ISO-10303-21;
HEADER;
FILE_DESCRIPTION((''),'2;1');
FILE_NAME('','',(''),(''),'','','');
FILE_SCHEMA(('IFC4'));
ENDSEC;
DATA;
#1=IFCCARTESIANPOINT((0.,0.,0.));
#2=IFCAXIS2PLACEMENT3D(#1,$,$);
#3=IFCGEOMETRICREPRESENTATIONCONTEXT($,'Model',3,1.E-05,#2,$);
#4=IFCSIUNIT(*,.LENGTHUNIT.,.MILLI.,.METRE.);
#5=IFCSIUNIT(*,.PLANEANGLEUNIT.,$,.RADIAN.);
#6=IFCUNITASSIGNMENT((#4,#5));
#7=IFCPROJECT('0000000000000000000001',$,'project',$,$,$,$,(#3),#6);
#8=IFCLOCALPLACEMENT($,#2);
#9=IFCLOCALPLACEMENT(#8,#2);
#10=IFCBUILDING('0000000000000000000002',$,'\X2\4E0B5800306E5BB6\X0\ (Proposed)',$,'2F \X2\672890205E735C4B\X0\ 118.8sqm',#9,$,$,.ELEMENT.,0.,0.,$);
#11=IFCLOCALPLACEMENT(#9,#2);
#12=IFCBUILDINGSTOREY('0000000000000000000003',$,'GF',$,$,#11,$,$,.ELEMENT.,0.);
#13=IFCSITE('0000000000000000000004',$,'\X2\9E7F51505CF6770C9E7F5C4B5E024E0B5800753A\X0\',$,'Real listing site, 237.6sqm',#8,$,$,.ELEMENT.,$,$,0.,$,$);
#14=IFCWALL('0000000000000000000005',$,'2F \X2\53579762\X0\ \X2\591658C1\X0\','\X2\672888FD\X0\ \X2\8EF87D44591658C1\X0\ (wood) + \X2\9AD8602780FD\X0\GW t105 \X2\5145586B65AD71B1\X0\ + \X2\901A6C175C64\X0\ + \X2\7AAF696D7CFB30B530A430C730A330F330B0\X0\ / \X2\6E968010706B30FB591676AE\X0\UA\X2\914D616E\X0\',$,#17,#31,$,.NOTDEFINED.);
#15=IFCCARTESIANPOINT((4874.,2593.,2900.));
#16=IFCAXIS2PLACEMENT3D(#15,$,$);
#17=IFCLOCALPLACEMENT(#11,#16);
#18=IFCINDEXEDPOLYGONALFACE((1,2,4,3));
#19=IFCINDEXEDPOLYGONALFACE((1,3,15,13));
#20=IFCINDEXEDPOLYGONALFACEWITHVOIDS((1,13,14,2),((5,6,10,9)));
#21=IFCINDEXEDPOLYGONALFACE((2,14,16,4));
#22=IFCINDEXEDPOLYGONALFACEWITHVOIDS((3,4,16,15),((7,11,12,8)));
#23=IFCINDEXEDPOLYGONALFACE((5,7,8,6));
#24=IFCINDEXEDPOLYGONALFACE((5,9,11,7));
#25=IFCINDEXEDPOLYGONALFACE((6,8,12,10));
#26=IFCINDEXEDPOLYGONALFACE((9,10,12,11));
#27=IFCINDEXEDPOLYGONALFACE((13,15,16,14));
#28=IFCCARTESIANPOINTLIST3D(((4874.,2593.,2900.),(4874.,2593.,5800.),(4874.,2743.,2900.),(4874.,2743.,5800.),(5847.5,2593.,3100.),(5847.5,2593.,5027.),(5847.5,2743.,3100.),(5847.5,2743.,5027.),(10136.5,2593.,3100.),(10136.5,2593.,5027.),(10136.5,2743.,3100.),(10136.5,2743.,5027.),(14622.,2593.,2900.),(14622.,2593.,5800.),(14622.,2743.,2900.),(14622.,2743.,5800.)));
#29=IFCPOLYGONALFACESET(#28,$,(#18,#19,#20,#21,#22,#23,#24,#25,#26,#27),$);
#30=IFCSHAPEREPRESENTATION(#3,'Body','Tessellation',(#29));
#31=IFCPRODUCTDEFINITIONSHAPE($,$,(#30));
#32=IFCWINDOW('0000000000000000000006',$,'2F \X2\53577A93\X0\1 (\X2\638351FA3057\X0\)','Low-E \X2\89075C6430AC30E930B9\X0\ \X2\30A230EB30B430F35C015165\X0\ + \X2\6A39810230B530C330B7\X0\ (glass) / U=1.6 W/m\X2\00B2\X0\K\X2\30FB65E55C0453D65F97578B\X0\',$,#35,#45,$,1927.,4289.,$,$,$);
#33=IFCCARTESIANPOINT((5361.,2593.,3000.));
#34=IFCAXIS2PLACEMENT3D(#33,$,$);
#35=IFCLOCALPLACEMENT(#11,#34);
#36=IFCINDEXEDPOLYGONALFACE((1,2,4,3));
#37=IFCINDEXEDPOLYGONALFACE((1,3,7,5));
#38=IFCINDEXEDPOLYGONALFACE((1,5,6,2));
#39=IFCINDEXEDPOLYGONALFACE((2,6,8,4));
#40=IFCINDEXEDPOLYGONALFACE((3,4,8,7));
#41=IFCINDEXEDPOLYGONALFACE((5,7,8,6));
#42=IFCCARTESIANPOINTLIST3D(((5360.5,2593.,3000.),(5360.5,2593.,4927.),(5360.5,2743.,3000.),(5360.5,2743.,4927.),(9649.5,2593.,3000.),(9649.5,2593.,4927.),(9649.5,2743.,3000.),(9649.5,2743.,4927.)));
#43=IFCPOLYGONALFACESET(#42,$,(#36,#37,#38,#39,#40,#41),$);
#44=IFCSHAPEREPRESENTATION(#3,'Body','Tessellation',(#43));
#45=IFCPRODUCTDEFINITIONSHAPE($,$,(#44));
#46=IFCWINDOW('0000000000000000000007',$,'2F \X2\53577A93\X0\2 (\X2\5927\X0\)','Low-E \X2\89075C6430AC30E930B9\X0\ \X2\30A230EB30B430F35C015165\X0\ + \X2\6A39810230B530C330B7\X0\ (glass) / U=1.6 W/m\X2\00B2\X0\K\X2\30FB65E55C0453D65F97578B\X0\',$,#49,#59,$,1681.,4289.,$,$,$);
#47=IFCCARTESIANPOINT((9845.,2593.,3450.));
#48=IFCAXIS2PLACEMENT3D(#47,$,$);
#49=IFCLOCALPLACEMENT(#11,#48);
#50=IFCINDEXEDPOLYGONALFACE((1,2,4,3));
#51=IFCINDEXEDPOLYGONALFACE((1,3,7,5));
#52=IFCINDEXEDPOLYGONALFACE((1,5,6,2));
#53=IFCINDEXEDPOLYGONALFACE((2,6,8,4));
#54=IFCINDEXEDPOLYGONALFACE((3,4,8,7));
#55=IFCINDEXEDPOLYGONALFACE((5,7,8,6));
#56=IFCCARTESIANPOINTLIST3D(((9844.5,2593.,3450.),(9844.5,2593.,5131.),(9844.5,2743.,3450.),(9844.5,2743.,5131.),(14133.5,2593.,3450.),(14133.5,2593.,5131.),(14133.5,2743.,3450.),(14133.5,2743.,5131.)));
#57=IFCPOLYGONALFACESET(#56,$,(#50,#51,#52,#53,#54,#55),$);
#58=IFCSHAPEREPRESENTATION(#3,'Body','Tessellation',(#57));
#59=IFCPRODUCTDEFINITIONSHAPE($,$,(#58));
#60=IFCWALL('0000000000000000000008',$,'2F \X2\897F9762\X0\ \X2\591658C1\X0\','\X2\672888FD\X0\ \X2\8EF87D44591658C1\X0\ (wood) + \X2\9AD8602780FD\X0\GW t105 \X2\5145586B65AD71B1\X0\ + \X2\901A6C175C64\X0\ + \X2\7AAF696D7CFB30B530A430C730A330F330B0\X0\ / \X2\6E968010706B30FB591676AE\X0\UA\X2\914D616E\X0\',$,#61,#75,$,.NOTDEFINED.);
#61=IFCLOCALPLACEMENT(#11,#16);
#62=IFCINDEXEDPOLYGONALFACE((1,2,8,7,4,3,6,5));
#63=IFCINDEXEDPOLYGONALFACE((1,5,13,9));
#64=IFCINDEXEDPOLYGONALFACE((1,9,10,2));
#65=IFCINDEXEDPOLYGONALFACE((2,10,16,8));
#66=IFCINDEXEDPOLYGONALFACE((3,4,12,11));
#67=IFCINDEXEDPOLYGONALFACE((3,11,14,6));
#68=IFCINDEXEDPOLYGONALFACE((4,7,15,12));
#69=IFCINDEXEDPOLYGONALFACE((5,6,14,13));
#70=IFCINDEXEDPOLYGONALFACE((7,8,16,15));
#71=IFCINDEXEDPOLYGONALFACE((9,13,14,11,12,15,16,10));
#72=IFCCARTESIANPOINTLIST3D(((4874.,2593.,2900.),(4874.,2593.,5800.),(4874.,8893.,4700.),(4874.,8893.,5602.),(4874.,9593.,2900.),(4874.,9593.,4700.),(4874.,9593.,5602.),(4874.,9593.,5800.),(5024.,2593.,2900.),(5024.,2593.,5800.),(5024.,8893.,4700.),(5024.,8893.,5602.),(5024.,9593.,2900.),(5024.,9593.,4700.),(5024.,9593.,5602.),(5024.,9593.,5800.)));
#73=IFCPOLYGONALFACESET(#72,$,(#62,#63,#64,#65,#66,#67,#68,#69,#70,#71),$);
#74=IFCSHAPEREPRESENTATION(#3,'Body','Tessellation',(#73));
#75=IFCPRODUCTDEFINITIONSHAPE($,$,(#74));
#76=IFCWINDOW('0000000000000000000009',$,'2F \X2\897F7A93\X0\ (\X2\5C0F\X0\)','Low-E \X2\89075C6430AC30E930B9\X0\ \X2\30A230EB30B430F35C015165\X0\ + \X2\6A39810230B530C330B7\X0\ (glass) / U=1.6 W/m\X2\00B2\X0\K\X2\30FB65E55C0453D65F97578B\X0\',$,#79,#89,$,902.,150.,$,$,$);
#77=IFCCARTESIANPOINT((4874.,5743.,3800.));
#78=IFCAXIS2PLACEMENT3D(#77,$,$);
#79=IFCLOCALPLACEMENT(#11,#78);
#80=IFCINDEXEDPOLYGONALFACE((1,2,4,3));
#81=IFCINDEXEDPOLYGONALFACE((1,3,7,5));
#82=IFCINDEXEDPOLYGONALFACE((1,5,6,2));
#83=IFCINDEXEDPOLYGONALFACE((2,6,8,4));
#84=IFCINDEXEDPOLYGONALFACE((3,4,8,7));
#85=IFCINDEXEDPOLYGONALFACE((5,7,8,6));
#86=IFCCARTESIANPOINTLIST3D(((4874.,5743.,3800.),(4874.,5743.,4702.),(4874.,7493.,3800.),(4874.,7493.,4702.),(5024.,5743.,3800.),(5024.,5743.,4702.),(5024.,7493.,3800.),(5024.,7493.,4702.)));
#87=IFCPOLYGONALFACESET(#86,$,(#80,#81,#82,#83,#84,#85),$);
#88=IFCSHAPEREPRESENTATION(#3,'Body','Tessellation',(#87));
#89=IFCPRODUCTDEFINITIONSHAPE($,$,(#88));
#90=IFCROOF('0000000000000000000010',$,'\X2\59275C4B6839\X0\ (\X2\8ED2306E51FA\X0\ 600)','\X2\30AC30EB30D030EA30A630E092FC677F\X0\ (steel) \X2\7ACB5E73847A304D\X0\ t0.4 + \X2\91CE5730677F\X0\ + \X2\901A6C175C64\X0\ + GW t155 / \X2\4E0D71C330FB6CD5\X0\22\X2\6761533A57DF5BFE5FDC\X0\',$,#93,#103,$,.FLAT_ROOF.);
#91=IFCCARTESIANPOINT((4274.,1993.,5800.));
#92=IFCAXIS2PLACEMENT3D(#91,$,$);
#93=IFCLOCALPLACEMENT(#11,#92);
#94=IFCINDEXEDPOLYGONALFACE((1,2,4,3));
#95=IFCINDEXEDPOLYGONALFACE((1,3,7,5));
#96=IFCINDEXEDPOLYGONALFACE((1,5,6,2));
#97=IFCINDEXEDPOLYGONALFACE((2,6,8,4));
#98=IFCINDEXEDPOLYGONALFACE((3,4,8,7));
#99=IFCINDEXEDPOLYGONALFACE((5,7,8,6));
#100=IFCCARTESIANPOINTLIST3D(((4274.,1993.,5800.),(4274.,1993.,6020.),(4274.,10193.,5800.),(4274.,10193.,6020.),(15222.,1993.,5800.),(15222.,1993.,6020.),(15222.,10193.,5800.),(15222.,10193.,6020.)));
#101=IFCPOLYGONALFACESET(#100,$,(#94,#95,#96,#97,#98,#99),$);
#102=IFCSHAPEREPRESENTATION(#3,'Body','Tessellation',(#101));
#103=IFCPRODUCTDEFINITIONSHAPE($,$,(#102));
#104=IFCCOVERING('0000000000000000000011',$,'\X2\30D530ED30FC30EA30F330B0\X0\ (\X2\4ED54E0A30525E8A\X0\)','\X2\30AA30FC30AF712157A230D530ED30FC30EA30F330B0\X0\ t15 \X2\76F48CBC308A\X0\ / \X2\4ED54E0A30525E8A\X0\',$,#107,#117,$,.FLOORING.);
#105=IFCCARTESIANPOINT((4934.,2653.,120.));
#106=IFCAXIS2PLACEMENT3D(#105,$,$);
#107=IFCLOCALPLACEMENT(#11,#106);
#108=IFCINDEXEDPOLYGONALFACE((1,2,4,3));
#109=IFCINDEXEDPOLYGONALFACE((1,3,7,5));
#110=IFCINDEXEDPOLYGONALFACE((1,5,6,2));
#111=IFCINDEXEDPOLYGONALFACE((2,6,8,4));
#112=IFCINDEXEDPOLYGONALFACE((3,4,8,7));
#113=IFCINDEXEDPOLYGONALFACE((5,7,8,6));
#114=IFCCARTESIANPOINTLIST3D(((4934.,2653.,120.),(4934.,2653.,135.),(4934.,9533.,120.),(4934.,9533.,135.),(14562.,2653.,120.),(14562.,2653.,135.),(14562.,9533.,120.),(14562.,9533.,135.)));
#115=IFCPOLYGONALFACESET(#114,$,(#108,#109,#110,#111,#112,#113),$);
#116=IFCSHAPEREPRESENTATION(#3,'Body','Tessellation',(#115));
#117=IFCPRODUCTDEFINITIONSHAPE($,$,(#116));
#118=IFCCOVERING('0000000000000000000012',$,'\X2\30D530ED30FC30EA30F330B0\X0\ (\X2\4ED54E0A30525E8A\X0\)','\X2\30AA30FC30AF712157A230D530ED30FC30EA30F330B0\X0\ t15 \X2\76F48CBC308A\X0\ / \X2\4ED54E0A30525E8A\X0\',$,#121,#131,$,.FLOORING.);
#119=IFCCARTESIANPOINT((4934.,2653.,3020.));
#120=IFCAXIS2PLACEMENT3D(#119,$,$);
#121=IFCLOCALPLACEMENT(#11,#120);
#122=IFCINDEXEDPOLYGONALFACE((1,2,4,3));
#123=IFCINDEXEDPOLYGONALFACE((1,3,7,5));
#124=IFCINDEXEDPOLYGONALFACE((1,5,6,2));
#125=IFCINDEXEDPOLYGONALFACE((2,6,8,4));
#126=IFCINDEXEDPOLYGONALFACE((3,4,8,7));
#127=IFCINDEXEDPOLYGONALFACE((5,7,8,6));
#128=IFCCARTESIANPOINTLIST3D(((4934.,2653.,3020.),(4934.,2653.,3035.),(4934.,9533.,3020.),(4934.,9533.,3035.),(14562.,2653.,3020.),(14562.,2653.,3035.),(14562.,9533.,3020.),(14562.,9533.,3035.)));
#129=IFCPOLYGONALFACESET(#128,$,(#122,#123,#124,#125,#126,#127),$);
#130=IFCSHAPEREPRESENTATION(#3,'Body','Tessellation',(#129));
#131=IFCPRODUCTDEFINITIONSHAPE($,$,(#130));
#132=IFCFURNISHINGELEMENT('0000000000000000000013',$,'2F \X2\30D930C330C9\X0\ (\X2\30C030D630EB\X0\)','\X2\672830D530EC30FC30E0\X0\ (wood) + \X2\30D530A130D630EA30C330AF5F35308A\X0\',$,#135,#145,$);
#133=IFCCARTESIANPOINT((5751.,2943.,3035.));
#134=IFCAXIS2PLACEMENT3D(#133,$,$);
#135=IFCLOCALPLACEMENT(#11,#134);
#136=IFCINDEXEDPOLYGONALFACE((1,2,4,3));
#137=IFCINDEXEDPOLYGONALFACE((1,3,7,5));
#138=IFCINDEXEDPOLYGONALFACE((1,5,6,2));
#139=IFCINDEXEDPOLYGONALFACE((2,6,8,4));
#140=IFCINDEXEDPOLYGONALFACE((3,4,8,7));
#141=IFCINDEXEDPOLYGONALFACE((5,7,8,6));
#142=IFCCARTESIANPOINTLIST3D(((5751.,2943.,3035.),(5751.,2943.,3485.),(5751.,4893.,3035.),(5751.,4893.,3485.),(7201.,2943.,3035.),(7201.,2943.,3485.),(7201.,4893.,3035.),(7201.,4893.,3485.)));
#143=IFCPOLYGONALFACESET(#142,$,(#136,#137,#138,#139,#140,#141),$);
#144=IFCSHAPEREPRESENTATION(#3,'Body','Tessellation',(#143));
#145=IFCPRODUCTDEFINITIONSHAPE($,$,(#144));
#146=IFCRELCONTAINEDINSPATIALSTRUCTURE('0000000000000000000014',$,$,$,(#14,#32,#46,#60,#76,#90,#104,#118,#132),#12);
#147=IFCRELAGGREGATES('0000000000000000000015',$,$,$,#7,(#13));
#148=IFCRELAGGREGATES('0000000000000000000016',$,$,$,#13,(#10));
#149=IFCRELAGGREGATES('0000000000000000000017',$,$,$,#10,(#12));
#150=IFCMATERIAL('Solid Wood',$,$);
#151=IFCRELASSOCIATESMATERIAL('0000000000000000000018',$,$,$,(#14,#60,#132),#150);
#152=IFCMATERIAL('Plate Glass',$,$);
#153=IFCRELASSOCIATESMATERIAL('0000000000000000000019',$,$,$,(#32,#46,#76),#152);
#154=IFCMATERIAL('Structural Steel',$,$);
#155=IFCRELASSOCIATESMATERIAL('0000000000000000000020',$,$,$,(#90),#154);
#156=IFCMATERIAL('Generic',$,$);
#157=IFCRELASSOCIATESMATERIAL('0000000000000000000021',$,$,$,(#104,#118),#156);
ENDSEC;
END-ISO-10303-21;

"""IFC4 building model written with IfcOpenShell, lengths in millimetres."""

from ifc_helpers import new_model, si_unit, frame, frame_2d, origin, place, context, project, spatial, rectangle, extrude, material, element, fill, save


model = new_model("IFC4")

# Units and contexts
model_context = context("Model", 3, precision=1e-05, world=origin())
ifc_project = project(units=[si_unit("LENGTHUNIT", "METRE", prefix="MILLI"), si_unit("PLANEANGLEUNIT", "RADIAN")], contexts=[model_context])

# Site, building, storey
site_placement = place(None, origin())
site = spatial("IfcSite", under=ifc_project, at=site_placement, Name="鹿児島県鹿屋市下堀町", ObjectType="Real listing site, 237.6sqm", CompositionType="ELEMENT", RefElevation=0.0)
building_placement = place(site_placement, origin())
building = spatial("IfcBuilding", under=site, at=building_placement, Name="下堀の家 (Proposed)", ObjectType="2F 木造平屋 118.8sqm", CompositionType="ELEMENT", ElevationOfRefHeight=0.0, ElevationOfTerrain=0.0)
storey_placement = place(building_placement, origin())
storey = spatial("IfcBuildingStorey", under=building, at=storey_placement, Name="GF", CompositionType="ELEMENT", Elevation=0.0)

# Shared definitions
ifc_material_1 = material(Name="Solid Wood")

# Shared definitions
ifc_material_2 = material(Name="Plate Glass")

# Wall, openings, windows
wall_1_placement = place(storey_placement, frame((4874.0, 2593.0, 2900.0)))
wall_1 = element("IfcWall", 1, at=wall_1_placement, inside=storey, material=ifc_material_1, Name="2F 南面 外壁", Description="木製 軸組外壁 (wood) + 高性能GW t105 充填断熱 + 通気層 + 窯業系サイディング / 準耐火・外皮UA配慮", PredefinedType="NOTDEFINED", context=model_context, shape_type="SweptSolid", body=[
    extrude(rectangle(XDim=9748.0, YDim=150.0, at=frame_2d((4874.0, 75.0))), frame((4874.0, 2593.0, 2900.0)), (0.0, 0.0, 1.0), 2900.0),
])
opening_1_placement = place(storey_placement, frame((5361.0, 2593.0, 3000.0)))
opening_1 = element("IfcOpeningElement", 2, at=opening_1_placement, cuts=wall_1, PredefinedType="NOTDEFINED", context=model_context, shape_type="SweptSolid", body=[
    extrude(rectangle(XDim=4289.0, YDim=150.0, at=frame_2d((2144.0, 75.0))), frame((5361.0, 2593.0, 3000.0)), (0.0, 0.0, 1.0), 1927.0),
])
opening_2_placement = place(storey_placement, frame((9845.0, 2593.0, 3450.0)))
opening_2 = element("IfcOpeningElement", 3, at=opening_2_placement, cuts=wall_1, PredefinedType="NOTDEFINED", context=model_context, shape_type="SweptSolid", body=[
    extrude(rectangle(XDim=4289.0, YDim=150.0, at=frame_2d((2144.0, 75.0))), frame((9845.0, 2593.0, 3450.0)), (0.0, 0.0, 1.0), 1681.0),
])
window_1_placement = place(storey_placement, frame((5361.0, 2593.0, 3000.0)))
window_1 = element("IfcWindow", 4, at=window_1_placement, inside=storey, material=ifc_material_2, Name="2F 南窓1 (掃出し)", Description="Low-E 複層ガラス アルゴン封入 + 樹脂サッシ (glass) / U=1.6 W/m²K・日射取得型", OverallHeight=1927.0, OverallWidth=4289.0, context=model_context, shape_type="SweptSolid", body=[
    extrude(rectangle(XDim=4289.0, YDim=150.0, at=frame_2d((2144.0, 75.0))), frame((5361.0, 2593.0, 3000.0)), (0.0, 0.0, 1.0), 1927.0),
])
fill(opening_1, window_1)
window_2_placement = place(storey_placement, frame((9845.0, 2593.0, 3450.0)))
window_2 = element("IfcWindow", 5, at=window_2_placement, inside=storey, material=ifc_material_2, Name="2F 南窓2 (大)", Description="Low-E 複層ガラス アルゴン封入 + 樹脂サッシ (glass) / U=1.6 W/m²K・日射取得型", OverallHeight=1681.0, OverallWidth=4289.0, context=model_context, shape_type="SweptSolid", body=[
    extrude(rectangle(XDim=4289.0, YDim=150.0, at=frame_2d((2144.0, 75.0))), frame((9845.0, 2593.0, 3450.0)), (0.0, 0.0, 1.0), 1681.0),
])
fill(opening_2, window_2)

# Wall, opening, window
wall_2_placement = place(storey_placement, frame((4874.0, 2593.0, 2900.0)))
wall_2 = element("IfcWall", 6, at=wall_2_placement, inside=storey, material=ifc_material_1, Name="2F 西面 外壁", Description="木製 軸組外壁 (wood) + 高性能GW t105 充填断熱 + 通気層 + 窯業系サイディング / 準耐火・外皮UA配慮", PredefinedType="NOTDEFINED", context=model_context, shape_type="SweptSolid", body=[
    extrude(rectangle(XDim=150.0, YDim=7000.0, at=frame_2d((75.0, 3500.0))), frame((4874.0, 2593.0, 2900.0)), (0.0, 0.0, 1.0), 2900.0),
])
opening_3_placement = place(storey_placement, frame((4874.0, 5743.0, 3800.0)))
opening_3 = element("IfcOpeningElement", 7, at=opening_3_placement, cuts=wall_2, PredefinedType="NOTDEFINED", context=model_context, shape_type="SweptSolid", body=[
    extrude(rectangle(XDim=150.0, YDim=1750.0, at=frame_2d((75.0, 875.0))), frame((4874.0, 5743.0, 3800.0)), (0.0, 0.0, 1.0), 902.0),
])
window_3_placement = place(storey_placement, frame((4874.0, 5743.0, 3800.0)))
window_3 = element("IfcWindow", 8, at=window_3_placement, inside=storey, material=ifc_material_2, Name="2F 西窓 (小)", Description="Low-E 複層ガラス アルゴン封入 + 樹脂サッシ (glass) / U=1.6 W/m²K・日射取得型", OverallHeight=902.0, OverallWidth=150.0, context=model_context, shape_type="SweptSolid", body=[
    extrude(rectangle(XDim=150.0, YDim=1750.0, at=frame_2d((75.0, 875.0))), frame((4874.0, 5743.0, 3800.0)), (0.0, 0.0, 1.0), 902.0),
])
fill(opening_3, window_3)

# Roof
ifc_material_3 = material(Name="Structural Steel")
roof_placement = place(storey_placement, frame((4274.0, 1993.0, 5800.0)))
element("IfcRoof", 9, at=roof_placement, inside=storey, material=ifc_material_3, Name="大屋根 (軒の出 600)", Description="ガルバリウム鋼板 (steel) 立平葺き t0.4 + 野地板 + 通気層 + GW t155 / 不燃・法22条区域対応", PredefinedType="FLAT_ROOF", context=model_context, shape_type="SweptSolid", body=[
    extrude(rectangle(XDim=10948.0, YDim=8200.0, at=frame_2d((5474.0, 4100.0))), frame((4274.0, 1993.0, 5800.0)), (0.0, 0.0, 1.0), 220.0),
])

# Coverings
ifc_material_4 = material(Name="Generic")
covering_1_placement = place(storey_placement, frame((4934.0, 2653.0, 120.0)))
element("IfcCovering", 10, at=covering_1_placement, inside=storey, material=ifc_material_4, Name="フローリング (仕上げ床)", Description="オーク無垢フローリング t15 直貼り / 仕上げ床", PredefinedType="FLOORING", context=model_context, shape_type="SweptSolid", body=[
    extrude(rectangle(XDim=9628.0, YDim=6880.0, at=frame_2d((4814.0, 3440.0))), frame((4934.0, 2653.0, 120.0)), (0.0, 0.0, 1.0), 15.0),
])
covering_2_placement = place(storey_placement, frame((4934.0, 2653.0, 3020.0)))
element("IfcCovering", 11, at=covering_2_placement, inside=storey, material=ifc_material_4, Name="フローリング (仕上げ床)", Description="オーク無垢フローリング t15 直貼り / 仕上げ床", PredefinedType="FLOORING", context=model_context, shape_type="SweptSolid", body=[
    extrude(rectangle(XDim=9628.0, YDim=6880.0, at=frame_2d((4814.0, 3440.0))), frame((4934.0, 2653.0, 3020.0)), (0.0, 0.0, 1.0), 15.0),
])

# Furnishing element
furnishing_placement = place(storey_placement, frame((5751.0, 2943.0, 3035.0)))
element("IfcFurnishingElement", 12, at=furnishing_placement, inside=storey, material=ifc_material_1, Name="2F ベッド (ダブル)", Description="木フレーム (wood) + ファブリック張り", context=model_context, shape_type="SweptSolid", body=[
    extrude(rectangle(XDim=1450.0, YDim=1950.0, at=frame_2d((725.0, 975.0))), frame((5751.0, 2943.0, 3035.0)), (0.0, 0.0, 1.0), 450.0),
])

save(model, "model.ifc")
